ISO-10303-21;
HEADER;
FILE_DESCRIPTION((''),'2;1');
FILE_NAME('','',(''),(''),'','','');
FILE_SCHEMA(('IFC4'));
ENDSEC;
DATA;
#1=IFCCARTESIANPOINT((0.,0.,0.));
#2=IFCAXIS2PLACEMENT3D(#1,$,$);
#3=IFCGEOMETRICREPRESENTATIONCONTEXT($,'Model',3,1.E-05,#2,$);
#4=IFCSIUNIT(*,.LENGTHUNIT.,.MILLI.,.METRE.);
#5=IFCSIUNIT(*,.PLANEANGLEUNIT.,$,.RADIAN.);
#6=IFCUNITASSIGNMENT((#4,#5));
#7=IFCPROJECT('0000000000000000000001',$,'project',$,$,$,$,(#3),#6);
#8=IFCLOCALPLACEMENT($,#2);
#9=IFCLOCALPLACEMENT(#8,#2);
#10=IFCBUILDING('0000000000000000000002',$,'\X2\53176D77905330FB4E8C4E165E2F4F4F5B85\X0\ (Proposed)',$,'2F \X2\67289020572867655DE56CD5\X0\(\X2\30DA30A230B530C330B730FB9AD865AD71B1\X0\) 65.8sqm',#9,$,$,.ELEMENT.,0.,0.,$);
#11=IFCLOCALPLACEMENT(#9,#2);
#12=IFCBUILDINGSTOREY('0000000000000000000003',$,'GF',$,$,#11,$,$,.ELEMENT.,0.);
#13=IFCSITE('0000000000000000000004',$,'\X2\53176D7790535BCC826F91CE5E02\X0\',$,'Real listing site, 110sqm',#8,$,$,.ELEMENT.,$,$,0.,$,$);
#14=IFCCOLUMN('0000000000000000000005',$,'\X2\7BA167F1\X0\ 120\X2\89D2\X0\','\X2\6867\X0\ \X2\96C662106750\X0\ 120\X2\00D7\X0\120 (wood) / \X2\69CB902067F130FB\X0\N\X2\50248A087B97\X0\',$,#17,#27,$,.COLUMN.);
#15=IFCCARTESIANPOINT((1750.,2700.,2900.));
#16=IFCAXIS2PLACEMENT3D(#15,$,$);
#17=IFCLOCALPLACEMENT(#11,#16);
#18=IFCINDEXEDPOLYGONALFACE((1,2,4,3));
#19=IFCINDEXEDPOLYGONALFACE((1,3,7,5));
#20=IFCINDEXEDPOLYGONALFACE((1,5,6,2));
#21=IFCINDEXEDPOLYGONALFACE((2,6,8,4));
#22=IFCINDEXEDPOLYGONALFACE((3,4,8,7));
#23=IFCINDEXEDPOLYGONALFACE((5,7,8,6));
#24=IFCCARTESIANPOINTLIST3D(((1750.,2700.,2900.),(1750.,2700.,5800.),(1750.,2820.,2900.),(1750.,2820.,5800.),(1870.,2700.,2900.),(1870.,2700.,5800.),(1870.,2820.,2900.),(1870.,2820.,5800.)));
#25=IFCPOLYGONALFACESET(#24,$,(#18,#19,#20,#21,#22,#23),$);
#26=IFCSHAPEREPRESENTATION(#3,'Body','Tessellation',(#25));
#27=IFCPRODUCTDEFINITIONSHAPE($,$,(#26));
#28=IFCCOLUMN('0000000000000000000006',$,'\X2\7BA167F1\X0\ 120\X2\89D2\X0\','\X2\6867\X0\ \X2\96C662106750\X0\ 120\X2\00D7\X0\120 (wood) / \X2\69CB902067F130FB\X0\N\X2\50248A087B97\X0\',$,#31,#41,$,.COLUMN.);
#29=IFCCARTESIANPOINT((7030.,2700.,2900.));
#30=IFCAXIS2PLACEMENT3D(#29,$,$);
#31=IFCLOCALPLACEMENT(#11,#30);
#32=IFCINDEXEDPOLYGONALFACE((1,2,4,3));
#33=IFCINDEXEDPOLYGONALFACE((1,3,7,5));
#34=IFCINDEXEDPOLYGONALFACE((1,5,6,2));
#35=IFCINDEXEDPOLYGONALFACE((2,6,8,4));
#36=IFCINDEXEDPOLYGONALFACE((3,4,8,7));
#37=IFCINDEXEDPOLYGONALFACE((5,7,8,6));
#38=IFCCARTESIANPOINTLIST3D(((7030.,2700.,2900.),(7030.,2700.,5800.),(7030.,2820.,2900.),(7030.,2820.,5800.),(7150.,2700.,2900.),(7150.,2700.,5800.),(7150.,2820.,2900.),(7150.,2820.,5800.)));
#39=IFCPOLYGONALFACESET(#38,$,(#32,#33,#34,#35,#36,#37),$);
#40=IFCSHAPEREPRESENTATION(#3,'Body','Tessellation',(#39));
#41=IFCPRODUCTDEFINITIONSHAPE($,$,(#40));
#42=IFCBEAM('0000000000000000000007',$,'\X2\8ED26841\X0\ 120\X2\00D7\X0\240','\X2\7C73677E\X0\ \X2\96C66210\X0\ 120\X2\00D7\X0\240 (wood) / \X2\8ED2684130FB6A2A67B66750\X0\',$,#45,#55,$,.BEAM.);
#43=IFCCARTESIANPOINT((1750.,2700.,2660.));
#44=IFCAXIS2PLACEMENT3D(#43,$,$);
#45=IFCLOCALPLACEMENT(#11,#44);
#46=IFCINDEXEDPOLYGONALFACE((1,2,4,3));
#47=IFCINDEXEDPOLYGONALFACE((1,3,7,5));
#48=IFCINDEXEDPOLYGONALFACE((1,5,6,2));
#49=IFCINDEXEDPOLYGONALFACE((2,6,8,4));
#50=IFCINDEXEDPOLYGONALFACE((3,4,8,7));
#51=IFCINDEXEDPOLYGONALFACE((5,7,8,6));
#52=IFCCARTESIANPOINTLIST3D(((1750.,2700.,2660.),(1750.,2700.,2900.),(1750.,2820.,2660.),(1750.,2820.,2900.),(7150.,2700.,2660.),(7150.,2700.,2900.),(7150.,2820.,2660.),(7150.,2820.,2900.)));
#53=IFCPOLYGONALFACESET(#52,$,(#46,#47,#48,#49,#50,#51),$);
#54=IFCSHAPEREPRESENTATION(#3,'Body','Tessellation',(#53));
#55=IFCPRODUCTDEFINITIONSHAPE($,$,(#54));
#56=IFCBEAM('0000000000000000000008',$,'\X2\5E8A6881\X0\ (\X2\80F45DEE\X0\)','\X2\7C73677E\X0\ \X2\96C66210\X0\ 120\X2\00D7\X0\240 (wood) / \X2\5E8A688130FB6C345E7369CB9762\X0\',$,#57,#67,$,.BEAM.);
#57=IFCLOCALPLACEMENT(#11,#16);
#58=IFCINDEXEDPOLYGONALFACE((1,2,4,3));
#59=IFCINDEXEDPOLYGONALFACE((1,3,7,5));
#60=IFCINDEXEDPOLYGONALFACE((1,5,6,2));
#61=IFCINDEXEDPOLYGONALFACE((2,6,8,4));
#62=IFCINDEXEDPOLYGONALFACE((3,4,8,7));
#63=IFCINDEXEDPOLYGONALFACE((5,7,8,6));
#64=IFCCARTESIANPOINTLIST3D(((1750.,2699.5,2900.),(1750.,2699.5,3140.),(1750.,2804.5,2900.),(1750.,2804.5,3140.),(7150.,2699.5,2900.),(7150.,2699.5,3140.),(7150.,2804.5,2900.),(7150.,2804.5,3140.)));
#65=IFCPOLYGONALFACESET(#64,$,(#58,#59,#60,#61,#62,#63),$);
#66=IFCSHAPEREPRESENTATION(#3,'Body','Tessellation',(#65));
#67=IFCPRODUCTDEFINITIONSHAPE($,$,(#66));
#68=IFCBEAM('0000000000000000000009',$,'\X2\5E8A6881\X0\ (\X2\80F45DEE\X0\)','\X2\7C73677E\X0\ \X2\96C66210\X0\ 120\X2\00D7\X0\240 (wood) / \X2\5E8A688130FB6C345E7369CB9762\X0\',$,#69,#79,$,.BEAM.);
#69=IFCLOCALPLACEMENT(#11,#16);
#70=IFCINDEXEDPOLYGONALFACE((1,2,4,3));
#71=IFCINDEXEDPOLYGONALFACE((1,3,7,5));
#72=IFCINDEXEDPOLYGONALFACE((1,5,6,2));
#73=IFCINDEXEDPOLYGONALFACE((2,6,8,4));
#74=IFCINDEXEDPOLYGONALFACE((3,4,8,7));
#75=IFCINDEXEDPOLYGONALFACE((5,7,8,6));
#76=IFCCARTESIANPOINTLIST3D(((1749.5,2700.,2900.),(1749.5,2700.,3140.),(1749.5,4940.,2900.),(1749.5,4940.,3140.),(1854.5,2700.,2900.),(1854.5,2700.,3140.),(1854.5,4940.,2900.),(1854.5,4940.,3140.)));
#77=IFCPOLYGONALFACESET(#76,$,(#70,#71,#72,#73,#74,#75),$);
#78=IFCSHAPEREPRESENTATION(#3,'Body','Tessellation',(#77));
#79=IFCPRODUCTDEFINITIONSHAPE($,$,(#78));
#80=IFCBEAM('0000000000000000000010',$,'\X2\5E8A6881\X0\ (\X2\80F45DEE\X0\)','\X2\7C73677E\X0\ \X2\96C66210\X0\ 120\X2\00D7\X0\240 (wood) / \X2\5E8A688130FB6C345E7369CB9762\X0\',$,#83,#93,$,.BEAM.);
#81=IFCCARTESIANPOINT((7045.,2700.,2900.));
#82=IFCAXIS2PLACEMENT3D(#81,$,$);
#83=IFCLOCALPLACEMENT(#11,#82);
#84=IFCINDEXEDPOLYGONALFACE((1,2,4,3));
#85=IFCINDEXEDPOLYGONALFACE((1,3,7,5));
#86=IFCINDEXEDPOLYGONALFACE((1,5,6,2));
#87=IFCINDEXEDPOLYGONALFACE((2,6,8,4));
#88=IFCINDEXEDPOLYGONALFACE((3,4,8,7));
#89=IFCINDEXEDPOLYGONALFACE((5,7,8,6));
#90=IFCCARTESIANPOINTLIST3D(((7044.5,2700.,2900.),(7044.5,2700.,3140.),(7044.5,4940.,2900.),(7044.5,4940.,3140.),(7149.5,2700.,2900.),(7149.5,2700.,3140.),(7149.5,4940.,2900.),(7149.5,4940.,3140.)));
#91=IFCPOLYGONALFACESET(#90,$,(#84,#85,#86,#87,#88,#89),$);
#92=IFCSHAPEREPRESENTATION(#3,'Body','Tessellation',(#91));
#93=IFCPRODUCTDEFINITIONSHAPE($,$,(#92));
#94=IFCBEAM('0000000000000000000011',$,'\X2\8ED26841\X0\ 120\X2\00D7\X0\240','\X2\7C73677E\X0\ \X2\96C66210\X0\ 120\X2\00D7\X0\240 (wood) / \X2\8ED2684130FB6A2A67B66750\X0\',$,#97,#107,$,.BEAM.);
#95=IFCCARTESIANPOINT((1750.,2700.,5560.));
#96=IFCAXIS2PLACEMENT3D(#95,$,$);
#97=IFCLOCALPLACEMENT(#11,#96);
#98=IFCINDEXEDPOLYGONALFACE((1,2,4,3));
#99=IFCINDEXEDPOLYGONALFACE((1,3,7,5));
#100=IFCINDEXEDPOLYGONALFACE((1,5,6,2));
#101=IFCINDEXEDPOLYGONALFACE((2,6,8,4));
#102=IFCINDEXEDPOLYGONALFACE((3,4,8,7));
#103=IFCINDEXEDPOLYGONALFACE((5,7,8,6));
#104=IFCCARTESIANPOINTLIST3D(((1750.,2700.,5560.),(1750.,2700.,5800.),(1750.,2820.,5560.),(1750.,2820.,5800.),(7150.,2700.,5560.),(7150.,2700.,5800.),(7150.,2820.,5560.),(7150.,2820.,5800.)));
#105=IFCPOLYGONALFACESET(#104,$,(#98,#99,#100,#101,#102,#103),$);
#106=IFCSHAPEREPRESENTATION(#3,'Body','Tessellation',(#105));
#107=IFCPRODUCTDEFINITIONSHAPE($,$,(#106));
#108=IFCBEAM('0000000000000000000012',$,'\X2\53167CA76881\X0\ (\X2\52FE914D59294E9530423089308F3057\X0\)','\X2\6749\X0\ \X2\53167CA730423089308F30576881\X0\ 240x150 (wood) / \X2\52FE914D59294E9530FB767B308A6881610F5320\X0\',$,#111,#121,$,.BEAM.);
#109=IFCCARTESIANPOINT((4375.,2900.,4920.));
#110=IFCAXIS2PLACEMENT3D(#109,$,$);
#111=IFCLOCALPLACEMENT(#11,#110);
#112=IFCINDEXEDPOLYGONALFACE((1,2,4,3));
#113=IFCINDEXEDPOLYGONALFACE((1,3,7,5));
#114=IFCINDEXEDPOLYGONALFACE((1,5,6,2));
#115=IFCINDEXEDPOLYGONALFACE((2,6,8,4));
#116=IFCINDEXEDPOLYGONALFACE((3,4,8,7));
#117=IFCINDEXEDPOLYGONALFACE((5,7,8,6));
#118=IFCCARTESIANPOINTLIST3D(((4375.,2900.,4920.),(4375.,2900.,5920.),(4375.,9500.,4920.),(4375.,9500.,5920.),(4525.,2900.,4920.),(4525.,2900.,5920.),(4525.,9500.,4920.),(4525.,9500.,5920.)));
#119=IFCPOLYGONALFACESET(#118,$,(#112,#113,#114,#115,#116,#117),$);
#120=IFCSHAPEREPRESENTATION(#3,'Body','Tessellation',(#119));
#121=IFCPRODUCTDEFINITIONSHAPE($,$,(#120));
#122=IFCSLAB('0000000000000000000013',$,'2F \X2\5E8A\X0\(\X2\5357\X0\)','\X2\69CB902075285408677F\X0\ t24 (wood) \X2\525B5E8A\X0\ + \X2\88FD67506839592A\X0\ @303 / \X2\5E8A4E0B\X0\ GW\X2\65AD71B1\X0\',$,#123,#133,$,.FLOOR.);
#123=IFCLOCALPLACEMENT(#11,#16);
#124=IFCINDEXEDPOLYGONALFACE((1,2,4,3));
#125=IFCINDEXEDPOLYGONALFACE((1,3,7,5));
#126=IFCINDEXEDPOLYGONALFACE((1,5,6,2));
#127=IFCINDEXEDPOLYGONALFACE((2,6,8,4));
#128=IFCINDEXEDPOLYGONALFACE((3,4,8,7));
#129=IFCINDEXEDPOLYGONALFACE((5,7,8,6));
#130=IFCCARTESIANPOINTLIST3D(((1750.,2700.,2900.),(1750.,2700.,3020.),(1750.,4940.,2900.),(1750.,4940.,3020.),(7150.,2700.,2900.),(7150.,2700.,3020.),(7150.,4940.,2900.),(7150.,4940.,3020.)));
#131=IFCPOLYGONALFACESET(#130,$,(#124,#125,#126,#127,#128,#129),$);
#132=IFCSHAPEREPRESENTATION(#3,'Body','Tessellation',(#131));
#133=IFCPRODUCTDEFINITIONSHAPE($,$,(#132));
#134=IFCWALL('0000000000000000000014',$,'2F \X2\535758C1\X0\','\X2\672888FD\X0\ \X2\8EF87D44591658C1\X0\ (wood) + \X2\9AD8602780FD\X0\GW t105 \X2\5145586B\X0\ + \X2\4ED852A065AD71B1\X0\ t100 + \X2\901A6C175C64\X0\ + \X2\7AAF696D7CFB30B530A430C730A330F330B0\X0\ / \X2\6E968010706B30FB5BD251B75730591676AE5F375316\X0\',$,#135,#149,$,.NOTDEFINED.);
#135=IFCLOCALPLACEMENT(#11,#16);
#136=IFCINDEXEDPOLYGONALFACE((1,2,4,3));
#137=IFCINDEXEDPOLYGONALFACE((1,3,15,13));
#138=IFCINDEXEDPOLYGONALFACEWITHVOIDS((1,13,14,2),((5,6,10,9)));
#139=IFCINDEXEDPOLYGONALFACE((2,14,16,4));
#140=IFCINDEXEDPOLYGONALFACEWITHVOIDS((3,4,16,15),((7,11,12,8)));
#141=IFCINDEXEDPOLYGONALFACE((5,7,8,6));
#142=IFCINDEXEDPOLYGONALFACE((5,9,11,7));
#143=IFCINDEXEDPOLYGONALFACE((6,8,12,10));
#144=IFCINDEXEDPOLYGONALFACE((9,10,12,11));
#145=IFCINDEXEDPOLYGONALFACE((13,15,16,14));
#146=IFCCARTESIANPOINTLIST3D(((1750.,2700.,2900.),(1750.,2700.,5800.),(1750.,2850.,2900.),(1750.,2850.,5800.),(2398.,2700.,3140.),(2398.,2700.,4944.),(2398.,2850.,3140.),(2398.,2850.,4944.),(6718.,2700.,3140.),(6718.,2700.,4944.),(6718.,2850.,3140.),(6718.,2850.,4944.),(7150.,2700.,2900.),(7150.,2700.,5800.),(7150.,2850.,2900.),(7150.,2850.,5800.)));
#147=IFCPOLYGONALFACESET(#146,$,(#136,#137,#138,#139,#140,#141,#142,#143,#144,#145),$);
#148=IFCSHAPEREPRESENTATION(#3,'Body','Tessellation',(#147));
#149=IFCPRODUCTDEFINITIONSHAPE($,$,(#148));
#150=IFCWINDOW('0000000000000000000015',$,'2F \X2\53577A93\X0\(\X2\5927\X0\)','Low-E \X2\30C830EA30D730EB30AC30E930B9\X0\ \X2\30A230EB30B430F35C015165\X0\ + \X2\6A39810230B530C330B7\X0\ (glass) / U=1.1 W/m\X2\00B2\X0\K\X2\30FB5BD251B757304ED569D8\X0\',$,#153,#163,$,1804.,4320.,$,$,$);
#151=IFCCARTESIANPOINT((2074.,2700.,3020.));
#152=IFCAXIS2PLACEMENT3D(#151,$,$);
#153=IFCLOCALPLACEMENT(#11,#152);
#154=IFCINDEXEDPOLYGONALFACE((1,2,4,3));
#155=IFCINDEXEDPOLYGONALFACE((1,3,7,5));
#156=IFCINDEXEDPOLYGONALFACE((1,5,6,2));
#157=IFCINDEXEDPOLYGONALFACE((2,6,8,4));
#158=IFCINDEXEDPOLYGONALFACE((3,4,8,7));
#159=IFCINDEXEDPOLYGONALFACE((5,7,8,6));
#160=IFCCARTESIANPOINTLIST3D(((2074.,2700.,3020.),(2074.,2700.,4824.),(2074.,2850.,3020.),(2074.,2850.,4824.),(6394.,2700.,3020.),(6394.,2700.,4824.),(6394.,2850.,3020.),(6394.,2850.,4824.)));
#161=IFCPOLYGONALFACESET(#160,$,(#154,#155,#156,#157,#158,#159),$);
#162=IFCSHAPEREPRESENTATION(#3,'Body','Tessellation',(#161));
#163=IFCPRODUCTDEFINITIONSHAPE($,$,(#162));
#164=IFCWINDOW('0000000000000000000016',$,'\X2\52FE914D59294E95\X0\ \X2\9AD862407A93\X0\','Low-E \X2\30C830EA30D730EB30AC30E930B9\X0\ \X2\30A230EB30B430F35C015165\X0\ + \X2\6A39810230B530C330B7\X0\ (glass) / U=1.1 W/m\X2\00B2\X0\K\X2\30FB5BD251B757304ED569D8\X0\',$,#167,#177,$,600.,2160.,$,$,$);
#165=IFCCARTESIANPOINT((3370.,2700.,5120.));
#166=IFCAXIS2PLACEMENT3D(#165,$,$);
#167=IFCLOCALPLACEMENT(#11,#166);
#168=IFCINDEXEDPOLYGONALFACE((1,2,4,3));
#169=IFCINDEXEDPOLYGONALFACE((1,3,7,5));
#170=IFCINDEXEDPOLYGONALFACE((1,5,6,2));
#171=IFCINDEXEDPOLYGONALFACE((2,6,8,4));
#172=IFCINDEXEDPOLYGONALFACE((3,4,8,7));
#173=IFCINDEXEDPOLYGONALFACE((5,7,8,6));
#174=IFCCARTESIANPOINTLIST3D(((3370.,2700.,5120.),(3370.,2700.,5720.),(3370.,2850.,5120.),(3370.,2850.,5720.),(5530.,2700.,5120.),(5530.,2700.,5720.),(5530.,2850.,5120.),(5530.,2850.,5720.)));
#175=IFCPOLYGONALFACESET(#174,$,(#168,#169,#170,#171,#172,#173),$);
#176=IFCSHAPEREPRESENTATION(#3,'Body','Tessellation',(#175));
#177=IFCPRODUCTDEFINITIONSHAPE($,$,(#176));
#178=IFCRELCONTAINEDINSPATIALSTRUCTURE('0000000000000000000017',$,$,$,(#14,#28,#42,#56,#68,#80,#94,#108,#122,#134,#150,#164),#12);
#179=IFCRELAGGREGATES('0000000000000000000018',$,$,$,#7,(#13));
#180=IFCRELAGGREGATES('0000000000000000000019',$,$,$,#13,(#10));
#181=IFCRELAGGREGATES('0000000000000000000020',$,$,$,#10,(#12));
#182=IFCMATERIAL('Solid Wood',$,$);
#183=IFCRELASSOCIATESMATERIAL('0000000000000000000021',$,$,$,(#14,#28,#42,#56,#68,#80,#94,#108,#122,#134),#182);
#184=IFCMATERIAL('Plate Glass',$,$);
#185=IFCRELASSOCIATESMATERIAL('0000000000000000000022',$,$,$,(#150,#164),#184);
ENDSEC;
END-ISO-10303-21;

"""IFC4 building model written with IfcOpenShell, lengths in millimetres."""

from ifc_helpers import new_model, si_unit, frame, frame_2d, origin, place, context, project, spatial, rectangle, extrude, material, element, fill, save


model = new_model("IFC4")

# Units and contexts
model_context = context("Model", 3, precision=1e-05, world=origin())
ifc_project = project(units=[si_unit("LENGTHUNIT", "METRE", prefix="MILLI"), si_unit("PLANEANGLEUNIT", "RADIAN")], contexts=[model_context])

# Site, building, storey
site_placement = place(None, origin())
site = spatial("IfcSite", under=ifc_project, at=site_placement, Name="北海道富良野市", ObjectType="Real listing site, 110sqm", CompositionType="ELEMENT", RefElevation=0.0)
building_placement = place(site_placement, origin())
building = spatial("IfcBuilding", under=site, at=building_placement, Name="北海道・二世帯住宅 (Proposed)", ObjectType="2F 木造在来工法(ペアサッシ・高断熱) 65.8sqm", CompositionType="ELEMENT", ElevationOfRefHeight=0.0, ElevationOfTerrain=0.0)
storey_placement = place(building_placement, origin())
storey = spatial("IfcBuildingStorey", under=building, at=storey_placement, Name="GF", CompositionType="ELEMENT", Elevation=0.0)

# Columns
ifc_material_1 = material(Name="Solid Wood")
column_1_placement = place(storey_placement, frame((1750.0, 2700.0, 2900.0)))
element("IfcColumn", 1, at=column_1_placement, inside=storey, material=ifc_material_1, Name="管柱 120角", Description="桧 集成材 120×120 (wood) / 構造柱・N値計算", PredefinedType="COLUMN", context=model_context, shape_type="SweptSolid", body=[
    extrude(rectangle(XDim=120.0, YDim=120.0, at=frame_2d((60.0, 60.0))), frame((1750.0, 2700.0, 2900.0)), (0.0, 0.0, 1.0), 2900.0),
])
column_2_placement = place(storey_placement, frame((7030.0, 2700.0, 2900.0)))
element("IfcColumn", 2, at=column_2_placement, inside=storey, material=ifc_material_1, Name="管柱 120角", Description="桧 集成材 120×120 (wood) / 構造柱・N値計算", PredefinedType="COLUMN", context=model_context, shape_type="SweptSolid", body=[
    extrude(rectangle(XDim=120.0, YDim=120.0, at=frame_2d((60.0, 60.0))), frame((7030.0, 2700.0, 2900.0)), (0.0, 0.0, 1.0), 2900.0),
])

# Beams
beam_1_placement = place(storey_placement, frame((1750.0, 2700.0, 2660.0)))
element("IfcBeam", 3, at=beam_1_placement, inside=storey, material=ifc_material_1, Name="軒桁 120×240", Description="米松 集成 120×240 (wood) / 軒桁・横架材", PredefinedType="BEAM", context=model_context, shape_type="SweptSolid", body=[
    extrude(rectangle(XDim=5400.0, YDim=120.0, at=frame_2d((2700.0, 60.0))), frame((1750.0, 2700.0, 2660.0)), (0.0, 0.0, 1.0), 240.0),
])
beam_2_placement = place(storey_placement, frame((1750.0, 2700.0, 2900.0)))
element("IfcBeam", 4, at=beam_2_placement, inside=storey, material=ifc_material_1, Name="床梁 (胴差)", Description="米松 集成 120×240 (wood) / 床梁・水平構面", PredefinedType="BEAM", context=model_context, shape_type="SweptSolid", body=[
    extrude(rectangle(XDim=5400.0, YDim=105.0, at=frame_2d((2700.0, 52.0))), frame((1750.0, 2700.0, 2900.0)), (0.0, 0.0, 1.0), 240.0),
])
beam_3_placement = place(storey_placement, frame((1750.0, 2700.0, 2900.0)))
element("IfcBeam", 5, at=beam_3_placement, inside=storey, material=ifc_material_1, Name="床梁 (胴差)", Description="米松 集成 120×240 (wood) / 床梁・水平構面", PredefinedType="BEAM", context=model_context, shape_type="SweptSolid", body=[
    extrude(rectangle(XDim=105.0, YDim=2240.0, at=frame_2d((52.0, 1120.0))), frame((1750.0, 2700.0, 2900.0)), (0.0, 0.0, 1.0), 240.0),
])
beam_4_placement = place(storey_placement, frame((7045.0, 2700.0, 2900.0)))
element("IfcBeam", 6, at=beam_4_placement, inside=storey, material=ifc_material_1, Name="床梁 (胴差)", Description="米松 集成 120×240 (wood) / 床梁・水平構面", PredefinedType="BEAM", context=model_context, shape_type="SweptSolid", body=[
    extrude(rectangle(XDim=105.0, YDim=2240.0, at=frame_2d((52.0, 1120.0))), frame((7045.0, 2700.0, 2900.0)), (0.0, 0.0, 1.0), 240.0),
])
beam_5_placement = place(storey_placement, frame((1750.0, 2700.0, 5560.0)))
element("IfcBeam", 7, at=beam_5_placement, inside=storey, material=ifc_material_1, Name="軒桁 120×240", Description="米松 集成 120×240 (wood) / 軒桁・横架材", PredefinedType="BEAM", context=model_context, shape_type="SweptSolid", body=[
    extrude(rectangle(XDim=5400.0, YDim=120.0, at=frame_2d((2700.0, 60.0))), frame((1750.0, 2700.0, 5560.0)), (0.0, 0.0, 1.0), 240.0),
])
beam_6_placement = place(storey_placement, frame((4375.0, 2900.0, 4920.0)))
element("IfcBeam", 8, at=beam_6_placement, inside=storey, material=ifc_material_1, Name="化粧梁 (勾配天井あらわし)", Description="杉 化粧あらわし梁 240x150 (wood) / 勾配天井・登り梁意匠", PredefinedType="BEAM", context=model_context, shape_type="SweptSolid", body=[
    extrude(rectangle(XDim=150.0, YDim=6600.0, at=frame_2d((75.0, 3300.0))), frame((4375.0, 2900.0, 4920.0)), (0.0, 0.0, 1.0), 1000.0),
])

# Slab
slab_placement = place(storey_placement, frame((1750.0, 2700.0, 2900.0)))
element("IfcSlab", 9, at=slab_placement, inside=storey, material=ifc_material_1, Name="2F 床(南)", Description="構造用合板 t24 (wood) 剛床 + 製材根太 @303 / 床下 GW断熱", PredefinedType="FLOOR", context=model_context, shape_type="SweptSolid", body=[
    extrude(rectangle(XDim=5400.0, YDim=2240.0, at=frame_2d((2700.0, 1120.0))), frame((1750.0, 2700.0, 2900.0)), (0.0, 0.0, 1.0), 120.0),
])

# Wall, openings, windows
wall_1_placement = place(storey_placement, frame((1750.0, 2700.0, 2900.0)))
wall_1 = element("IfcWall", 10, at=wall_1_placement, inside=storey, material=ifc_material_1, Name="2F 南壁", Description="木製 軸組外壁 (wood) + 高性能GW t105 充填 + 付加断熱 t100 + 通気層 + 窯業系サイディング / 準耐火・寒冷地外皮強化", PredefinedType="NOTDEFINED", context=model_context, shape_type="SweptSolid", body=[
    extrude(rectangle(XDim=5400.0, YDim=150.0, at=frame_2d((2700.0, 75.0))), frame((1750.0, 2700.0, 2900.0)), (0.0, 0.0, 1.0), 2900.0),
])
opening_1_placement = place(storey_placement, frame((2074.0, 2700.0, 3020.0)))
opening_1 = element("IfcOpeningElement", 11, at=opening_1_placement, cuts=wall_1, PredefinedType="NOTDEFINED", context=model_context, shape_type="SweptSolid", body=[
    extrude(rectangle(XDim=4320.0, YDim=150.0, at=frame_2d((2160.0, 75.0))), frame((2074.0, 2700.0, 3020.0)), (0.0, 0.0, 1.0), 1804.0),
])
opening_2_placement = place(storey_placement, frame((3370.0, 2700.0, 5120.0)))
opening_2 = element("IfcOpeningElement", 12, at=opening_2_placement, cuts=wall_1, PredefinedType="NOTDEFINED", context=model_context, shape_type="SweptSolid", body=[
    extrude(rectangle(XDim=2160.0, YDim=150.0, at=frame_2d((1080.0, 75.0))), frame((3370.0, 2700.0, 5120.0)), (0.0, 0.0, 1.0), 600.0),
])
ifc_material_2 = material(Name="Plate Glass")
window_1_placement = place(storey_placement, frame((2074.0, 2700.0, 3020.0)))
window_1 = element("IfcWindow", 13, at=window_1_placement, inside=storey, material=ifc_material_2, Name="2F 南窓(大)", Description="Low-E トリプルガラス アルゴン封入 + 樹脂サッシ (glass) / U=1.1 W/m²K・寒冷地仕様", OverallHeight=1804.0, OverallWidth=4320.0, context=model_context, shape_type="SweptSolid", body=[
    extrude(rectangle(XDim=4320.0, YDim=150.0, at=frame_2d((2160.0, 75.0))), frame((2074.0, 2700.0, 3020.0)), (0.0, 0.0, 1.0), 1804.0),
])
fill(opening_1, window_1)
window_2_placement = place(storey_placement, frame((3370.0, 2700.0, 5120.0)))
window_2 = element("IfcWindow", 14, at=window_2_placement, inside=storey, material=ifc_material_2, Name="勾配天井 高所窓", Description="Low-E トリプルガラス アルゴン封入 + 樹脂サッシ (glass) / U=1.1 W/m²K・寒冷地仕様", OverallHeight=600.0, OverallWidth=2160.0, context=model_context, shape_type="SweptSolid", body=[
    extrude(rectangle(XDim=2160.0, YDim=150.0, at=frame_2d((1080.0, 75.0))), frame((3370.0, 2700.0, 5120.0)), (0.0, 0.0, 1.0), 600.0),
])
fill(opening_2, window_2)

save(model, "model.ifc")
